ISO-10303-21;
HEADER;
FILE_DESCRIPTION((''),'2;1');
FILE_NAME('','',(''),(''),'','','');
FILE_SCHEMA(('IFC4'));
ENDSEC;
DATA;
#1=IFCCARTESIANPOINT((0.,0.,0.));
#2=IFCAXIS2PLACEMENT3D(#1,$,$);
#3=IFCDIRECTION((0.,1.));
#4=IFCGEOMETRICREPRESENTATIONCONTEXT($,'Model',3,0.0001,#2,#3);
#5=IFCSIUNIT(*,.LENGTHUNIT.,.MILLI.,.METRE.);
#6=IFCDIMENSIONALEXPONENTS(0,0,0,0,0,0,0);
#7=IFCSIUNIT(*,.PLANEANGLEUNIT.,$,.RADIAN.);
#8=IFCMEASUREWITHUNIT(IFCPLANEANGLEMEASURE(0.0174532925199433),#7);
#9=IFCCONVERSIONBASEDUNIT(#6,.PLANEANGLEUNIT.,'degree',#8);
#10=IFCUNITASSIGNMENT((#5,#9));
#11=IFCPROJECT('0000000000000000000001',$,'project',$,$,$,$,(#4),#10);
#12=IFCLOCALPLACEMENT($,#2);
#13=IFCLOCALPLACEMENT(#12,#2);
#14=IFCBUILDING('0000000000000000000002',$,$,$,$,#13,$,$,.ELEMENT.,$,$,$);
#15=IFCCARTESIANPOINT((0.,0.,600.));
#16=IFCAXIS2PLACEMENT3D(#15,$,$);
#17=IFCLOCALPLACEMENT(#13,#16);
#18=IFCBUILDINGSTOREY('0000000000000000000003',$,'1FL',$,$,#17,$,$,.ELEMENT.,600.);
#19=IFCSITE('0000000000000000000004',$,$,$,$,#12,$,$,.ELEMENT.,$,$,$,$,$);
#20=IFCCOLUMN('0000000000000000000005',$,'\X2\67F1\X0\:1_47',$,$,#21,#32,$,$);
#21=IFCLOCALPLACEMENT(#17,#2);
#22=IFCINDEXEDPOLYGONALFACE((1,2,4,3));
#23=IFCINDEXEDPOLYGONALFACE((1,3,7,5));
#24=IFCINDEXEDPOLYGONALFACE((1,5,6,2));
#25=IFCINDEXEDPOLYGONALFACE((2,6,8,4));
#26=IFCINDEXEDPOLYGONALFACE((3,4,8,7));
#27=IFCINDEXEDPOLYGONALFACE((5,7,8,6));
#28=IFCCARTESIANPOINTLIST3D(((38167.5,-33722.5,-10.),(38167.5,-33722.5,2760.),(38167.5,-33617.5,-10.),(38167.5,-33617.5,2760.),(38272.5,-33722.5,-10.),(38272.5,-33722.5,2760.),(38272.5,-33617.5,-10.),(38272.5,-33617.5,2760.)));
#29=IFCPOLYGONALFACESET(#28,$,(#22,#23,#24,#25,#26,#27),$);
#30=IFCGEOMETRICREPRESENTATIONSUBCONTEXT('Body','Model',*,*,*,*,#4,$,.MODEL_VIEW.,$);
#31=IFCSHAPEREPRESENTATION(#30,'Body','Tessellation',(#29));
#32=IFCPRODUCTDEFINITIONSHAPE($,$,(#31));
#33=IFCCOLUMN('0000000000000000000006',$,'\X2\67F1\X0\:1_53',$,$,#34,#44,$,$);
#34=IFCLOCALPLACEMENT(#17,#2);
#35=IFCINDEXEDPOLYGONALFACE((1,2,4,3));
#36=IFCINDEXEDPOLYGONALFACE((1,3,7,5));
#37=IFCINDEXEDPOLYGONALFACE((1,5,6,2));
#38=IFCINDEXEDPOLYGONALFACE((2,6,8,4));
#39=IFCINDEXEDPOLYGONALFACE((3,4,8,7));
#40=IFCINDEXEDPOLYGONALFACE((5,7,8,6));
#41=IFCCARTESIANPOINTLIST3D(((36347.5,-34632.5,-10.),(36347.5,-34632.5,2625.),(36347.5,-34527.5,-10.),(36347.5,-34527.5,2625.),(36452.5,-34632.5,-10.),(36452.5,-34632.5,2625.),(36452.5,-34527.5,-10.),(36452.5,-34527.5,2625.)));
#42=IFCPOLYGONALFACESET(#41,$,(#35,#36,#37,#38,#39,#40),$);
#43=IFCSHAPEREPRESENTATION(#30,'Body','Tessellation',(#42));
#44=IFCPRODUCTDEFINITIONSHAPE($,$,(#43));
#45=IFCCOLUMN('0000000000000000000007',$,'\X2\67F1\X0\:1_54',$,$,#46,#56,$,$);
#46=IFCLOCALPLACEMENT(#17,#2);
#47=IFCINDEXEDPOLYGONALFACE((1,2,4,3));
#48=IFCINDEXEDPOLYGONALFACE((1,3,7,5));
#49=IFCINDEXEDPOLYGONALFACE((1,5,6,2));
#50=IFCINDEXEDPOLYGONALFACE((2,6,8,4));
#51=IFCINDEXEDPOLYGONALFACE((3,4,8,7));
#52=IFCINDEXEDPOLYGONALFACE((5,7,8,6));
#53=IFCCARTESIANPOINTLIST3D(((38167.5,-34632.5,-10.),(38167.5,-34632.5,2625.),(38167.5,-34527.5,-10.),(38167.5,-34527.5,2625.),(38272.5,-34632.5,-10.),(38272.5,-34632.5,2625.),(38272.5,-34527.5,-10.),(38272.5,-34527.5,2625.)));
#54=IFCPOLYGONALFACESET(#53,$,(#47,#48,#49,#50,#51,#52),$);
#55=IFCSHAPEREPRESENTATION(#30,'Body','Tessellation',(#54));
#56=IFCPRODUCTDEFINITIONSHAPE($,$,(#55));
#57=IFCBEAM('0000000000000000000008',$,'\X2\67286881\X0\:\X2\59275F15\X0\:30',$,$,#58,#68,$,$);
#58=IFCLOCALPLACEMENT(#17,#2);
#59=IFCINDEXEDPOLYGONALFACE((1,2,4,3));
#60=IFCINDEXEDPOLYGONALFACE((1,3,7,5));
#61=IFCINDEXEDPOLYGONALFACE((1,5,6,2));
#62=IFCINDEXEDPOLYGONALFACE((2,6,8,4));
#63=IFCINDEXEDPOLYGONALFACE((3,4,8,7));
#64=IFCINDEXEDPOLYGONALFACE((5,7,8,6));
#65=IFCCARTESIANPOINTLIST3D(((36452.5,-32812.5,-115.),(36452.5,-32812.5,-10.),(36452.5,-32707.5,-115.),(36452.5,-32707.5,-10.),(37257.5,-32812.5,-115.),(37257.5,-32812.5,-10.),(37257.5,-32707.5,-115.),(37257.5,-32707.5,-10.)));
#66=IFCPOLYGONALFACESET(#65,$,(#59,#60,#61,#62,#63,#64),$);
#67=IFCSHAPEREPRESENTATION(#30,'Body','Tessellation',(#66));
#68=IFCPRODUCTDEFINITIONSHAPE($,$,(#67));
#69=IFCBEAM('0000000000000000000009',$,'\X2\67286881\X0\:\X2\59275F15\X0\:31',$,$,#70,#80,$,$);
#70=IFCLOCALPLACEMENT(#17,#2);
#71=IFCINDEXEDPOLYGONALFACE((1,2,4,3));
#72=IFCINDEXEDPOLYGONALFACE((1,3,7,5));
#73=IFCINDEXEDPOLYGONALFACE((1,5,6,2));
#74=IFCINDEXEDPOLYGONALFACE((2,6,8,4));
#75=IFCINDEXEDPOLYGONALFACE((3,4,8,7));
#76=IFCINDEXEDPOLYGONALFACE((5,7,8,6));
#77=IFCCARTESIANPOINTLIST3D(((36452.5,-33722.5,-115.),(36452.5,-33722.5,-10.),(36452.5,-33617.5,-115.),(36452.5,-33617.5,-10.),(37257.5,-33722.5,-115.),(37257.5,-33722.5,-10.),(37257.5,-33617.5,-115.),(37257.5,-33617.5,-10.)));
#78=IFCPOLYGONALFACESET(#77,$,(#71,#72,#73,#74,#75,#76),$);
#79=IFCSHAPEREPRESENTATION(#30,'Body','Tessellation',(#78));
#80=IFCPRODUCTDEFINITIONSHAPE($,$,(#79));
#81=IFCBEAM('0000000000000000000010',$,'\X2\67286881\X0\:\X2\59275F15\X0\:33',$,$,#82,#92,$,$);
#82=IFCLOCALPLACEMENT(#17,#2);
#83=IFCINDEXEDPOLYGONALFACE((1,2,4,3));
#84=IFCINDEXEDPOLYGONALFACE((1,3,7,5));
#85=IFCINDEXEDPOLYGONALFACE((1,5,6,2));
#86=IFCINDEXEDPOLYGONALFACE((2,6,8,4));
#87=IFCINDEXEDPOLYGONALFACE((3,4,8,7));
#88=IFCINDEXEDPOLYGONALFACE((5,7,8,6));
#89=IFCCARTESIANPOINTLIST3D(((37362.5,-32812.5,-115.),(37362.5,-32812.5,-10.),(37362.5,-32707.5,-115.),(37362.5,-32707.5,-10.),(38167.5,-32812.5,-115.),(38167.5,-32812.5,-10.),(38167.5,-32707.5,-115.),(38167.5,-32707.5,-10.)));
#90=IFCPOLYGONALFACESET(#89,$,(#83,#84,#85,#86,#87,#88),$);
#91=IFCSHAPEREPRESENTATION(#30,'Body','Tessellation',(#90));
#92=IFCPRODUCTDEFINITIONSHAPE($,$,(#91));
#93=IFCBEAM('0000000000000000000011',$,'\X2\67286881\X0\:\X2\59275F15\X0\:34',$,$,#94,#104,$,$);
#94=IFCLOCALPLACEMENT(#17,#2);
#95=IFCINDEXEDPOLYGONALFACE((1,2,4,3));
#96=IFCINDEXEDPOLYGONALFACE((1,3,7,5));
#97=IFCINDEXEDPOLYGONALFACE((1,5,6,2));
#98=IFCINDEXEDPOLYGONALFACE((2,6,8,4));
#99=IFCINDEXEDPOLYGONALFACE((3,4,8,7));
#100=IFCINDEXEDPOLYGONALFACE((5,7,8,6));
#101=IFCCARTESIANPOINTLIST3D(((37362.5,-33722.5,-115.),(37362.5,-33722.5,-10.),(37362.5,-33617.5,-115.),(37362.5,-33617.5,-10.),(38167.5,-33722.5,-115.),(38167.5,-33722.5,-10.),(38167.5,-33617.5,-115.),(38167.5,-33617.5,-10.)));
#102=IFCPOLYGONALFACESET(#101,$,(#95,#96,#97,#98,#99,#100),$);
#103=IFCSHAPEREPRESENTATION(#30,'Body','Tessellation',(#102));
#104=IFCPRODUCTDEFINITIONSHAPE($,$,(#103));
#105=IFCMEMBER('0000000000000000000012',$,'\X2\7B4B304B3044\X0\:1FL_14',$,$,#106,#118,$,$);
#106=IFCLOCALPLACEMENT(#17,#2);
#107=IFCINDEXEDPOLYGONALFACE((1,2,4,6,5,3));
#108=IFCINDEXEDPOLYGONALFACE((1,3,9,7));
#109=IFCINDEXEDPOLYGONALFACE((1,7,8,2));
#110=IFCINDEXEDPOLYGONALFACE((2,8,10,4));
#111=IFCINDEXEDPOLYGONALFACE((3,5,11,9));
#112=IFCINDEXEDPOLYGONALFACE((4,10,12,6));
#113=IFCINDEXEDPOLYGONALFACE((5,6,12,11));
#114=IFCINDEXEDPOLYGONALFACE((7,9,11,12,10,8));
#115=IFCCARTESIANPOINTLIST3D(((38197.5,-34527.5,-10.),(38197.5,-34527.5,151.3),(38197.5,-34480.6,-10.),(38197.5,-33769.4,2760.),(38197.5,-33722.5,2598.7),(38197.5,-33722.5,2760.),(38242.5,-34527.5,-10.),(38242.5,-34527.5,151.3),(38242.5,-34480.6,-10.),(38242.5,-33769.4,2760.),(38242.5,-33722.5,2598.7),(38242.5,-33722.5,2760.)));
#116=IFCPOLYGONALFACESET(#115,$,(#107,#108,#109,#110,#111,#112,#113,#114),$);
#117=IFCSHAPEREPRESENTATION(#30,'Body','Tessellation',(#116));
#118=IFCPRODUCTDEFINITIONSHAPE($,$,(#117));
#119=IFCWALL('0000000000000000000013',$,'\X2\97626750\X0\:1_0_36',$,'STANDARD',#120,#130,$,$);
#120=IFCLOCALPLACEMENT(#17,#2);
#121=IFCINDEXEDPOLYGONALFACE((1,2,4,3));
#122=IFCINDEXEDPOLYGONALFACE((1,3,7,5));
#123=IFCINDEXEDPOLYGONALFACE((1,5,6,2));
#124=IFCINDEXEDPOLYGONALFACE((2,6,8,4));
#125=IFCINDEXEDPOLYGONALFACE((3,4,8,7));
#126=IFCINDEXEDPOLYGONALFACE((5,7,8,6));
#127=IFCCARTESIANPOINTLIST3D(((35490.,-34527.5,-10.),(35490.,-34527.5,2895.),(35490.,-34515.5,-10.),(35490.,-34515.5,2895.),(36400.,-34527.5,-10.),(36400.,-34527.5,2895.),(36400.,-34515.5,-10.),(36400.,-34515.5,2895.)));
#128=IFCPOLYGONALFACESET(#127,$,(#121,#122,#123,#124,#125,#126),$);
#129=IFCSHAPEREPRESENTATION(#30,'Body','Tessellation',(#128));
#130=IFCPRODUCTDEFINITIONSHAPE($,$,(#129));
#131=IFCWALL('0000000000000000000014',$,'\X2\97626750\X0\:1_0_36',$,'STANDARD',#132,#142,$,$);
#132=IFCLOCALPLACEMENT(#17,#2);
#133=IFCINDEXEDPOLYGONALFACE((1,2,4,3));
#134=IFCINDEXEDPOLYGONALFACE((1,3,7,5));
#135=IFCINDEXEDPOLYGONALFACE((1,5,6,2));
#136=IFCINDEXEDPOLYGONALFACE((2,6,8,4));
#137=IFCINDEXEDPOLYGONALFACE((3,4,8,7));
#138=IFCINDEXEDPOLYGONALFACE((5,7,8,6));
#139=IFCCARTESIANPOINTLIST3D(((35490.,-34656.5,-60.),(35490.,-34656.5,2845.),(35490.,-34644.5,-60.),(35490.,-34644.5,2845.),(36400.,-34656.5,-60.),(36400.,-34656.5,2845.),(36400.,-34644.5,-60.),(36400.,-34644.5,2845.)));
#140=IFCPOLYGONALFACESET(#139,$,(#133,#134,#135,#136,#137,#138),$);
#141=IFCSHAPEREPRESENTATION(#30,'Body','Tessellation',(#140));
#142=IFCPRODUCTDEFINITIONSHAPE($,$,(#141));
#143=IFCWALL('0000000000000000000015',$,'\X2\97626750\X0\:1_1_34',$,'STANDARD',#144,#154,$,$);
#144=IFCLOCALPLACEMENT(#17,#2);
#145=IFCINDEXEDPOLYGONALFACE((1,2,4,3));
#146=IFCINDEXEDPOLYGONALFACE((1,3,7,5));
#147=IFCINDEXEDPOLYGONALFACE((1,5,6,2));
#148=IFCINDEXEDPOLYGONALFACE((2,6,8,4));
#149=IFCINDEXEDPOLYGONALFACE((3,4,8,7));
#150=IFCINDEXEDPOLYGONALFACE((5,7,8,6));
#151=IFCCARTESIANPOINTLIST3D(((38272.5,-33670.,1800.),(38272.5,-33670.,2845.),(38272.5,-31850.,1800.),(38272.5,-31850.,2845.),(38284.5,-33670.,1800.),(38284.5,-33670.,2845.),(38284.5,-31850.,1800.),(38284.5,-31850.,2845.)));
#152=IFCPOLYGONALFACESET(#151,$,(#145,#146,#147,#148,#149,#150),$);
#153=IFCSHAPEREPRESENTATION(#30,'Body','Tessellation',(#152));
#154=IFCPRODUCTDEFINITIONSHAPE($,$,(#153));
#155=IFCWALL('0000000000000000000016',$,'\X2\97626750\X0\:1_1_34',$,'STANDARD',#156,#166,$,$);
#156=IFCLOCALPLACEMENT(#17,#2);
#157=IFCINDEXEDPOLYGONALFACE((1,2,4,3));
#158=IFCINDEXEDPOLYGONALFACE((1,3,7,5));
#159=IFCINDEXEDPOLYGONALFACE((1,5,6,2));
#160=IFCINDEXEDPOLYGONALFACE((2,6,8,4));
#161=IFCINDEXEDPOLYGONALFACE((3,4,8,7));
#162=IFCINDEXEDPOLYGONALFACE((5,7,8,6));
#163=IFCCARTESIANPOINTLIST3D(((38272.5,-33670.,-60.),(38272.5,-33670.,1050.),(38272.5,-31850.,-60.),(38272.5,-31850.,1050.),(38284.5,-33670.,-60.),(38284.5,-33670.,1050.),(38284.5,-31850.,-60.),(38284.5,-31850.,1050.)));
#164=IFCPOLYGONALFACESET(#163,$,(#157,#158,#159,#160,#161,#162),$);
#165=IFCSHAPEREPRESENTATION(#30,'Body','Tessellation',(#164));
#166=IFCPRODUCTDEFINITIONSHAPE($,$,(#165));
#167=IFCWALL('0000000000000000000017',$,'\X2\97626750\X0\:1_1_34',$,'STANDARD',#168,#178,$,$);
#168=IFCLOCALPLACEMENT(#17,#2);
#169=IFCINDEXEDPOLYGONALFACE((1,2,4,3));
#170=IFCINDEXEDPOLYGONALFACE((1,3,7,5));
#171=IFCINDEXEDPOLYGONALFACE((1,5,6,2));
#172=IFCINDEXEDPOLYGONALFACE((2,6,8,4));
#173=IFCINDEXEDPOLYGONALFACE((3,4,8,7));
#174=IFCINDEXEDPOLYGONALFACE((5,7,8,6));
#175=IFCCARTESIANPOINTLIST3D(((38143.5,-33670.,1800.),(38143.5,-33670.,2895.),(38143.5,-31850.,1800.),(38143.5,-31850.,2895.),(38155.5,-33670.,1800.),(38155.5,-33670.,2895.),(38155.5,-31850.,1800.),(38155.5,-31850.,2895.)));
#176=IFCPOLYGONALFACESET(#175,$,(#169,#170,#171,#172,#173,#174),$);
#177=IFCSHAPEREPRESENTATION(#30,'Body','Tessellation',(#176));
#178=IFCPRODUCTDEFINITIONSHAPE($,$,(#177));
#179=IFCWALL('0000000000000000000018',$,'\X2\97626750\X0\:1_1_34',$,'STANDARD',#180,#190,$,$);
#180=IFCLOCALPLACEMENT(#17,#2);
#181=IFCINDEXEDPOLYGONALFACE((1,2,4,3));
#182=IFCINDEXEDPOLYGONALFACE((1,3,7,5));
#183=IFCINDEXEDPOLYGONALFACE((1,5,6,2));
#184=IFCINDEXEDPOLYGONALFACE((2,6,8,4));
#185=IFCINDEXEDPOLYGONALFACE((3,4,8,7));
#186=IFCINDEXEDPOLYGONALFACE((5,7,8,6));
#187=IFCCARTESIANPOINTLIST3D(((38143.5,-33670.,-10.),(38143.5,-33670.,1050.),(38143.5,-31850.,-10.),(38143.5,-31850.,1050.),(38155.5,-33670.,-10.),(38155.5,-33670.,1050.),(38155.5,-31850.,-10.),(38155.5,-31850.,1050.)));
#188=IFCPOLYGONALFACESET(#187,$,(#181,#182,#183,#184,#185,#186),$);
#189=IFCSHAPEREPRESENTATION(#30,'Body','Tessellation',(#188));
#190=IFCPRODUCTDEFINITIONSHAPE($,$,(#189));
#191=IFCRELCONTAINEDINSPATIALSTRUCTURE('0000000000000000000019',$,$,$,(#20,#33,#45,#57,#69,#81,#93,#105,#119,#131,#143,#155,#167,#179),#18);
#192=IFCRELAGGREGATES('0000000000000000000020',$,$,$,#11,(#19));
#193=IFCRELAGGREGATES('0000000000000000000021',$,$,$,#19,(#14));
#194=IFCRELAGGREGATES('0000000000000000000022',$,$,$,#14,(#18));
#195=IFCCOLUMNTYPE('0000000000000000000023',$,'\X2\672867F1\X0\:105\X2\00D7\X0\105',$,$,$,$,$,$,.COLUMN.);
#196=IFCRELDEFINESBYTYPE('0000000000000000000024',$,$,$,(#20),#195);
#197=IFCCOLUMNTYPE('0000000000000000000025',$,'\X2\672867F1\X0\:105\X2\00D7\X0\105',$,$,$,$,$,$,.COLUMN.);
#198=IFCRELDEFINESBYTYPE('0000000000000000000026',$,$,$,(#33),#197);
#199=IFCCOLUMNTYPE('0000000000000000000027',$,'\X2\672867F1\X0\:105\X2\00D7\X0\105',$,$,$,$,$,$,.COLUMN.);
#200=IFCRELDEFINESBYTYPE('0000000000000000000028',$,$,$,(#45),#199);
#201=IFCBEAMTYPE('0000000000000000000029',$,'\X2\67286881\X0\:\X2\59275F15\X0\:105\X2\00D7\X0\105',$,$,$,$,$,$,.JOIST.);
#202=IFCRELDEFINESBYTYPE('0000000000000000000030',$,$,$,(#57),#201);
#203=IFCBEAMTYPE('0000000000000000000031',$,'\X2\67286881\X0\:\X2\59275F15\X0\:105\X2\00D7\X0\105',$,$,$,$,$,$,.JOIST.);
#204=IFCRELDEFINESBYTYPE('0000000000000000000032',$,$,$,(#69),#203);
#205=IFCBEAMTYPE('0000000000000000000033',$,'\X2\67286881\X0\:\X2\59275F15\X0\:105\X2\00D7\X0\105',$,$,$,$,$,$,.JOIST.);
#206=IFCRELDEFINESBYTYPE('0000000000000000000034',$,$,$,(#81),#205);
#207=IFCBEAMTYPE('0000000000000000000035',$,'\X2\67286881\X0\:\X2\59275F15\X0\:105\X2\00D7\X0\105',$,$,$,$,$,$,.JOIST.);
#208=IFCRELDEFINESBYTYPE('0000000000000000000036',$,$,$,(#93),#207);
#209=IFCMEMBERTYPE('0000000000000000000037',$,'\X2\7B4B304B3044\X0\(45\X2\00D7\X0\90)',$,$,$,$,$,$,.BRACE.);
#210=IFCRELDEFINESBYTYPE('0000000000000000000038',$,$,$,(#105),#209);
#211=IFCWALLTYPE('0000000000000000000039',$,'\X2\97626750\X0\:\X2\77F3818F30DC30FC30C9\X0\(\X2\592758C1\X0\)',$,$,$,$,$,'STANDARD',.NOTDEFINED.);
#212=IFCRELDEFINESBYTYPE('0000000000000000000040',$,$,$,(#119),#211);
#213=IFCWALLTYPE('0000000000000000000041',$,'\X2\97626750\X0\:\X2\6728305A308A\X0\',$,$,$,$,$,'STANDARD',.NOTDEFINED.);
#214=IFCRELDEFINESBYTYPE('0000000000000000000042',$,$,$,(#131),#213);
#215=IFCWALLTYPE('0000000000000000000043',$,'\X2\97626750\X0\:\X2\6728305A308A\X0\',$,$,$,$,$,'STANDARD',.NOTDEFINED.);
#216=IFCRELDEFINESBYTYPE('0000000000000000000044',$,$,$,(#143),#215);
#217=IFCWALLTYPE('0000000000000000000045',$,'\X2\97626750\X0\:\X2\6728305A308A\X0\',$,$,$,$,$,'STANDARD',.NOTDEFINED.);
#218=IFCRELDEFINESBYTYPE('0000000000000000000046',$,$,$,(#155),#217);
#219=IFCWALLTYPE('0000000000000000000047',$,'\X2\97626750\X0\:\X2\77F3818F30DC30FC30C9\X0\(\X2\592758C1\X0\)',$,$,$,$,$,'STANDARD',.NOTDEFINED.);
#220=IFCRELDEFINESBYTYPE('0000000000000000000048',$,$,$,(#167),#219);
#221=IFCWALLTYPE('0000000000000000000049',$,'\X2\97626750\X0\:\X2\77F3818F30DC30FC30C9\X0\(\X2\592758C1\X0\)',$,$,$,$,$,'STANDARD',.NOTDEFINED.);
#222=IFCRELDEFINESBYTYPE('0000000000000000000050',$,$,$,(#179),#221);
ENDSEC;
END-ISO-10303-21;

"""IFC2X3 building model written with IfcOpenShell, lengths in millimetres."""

from ifc_helpers import new_model, entity, si_unit, converted_unit, direction, frame, origin, origin_with_axes, origin_2d, place, context, subcontext, project, spatial, polyline, rectangle, outline, extrude, type_object, element, save


model = new_model("IFC2X3")

# Units and contexts
model_context = context("Model", 3, precision=0.0001, world=origin(), true_north=direction((0.0, 1.0)))
body_context = subcontext(model_context, "Body", "Model", "MODEL_VIEW")
ifc_project = project(units=[si_unit("LENGTHUNIT", "METRE", prefix="MILLI"), converted_unit("PLANEANGLEUNIT", "degree", entity("IfcPlaneAngleMeasure", 0.0174532925199433), si_unit("PLANEANGLEUNIT", "RADIAN"), dimensions=[0, 0, 0, 0, 0, 0, 0])], contexts=[model_context])

# Site, building, storey
site_placement = place(None, origin())
site = spatial("IfcSite", under=ifc_project, at=site_placement, CompositionType="ELEMENT")
building_placement = place(site_placement, origin())
building = spatial("IfcBuilding", under=site, at=building_placement, CompositionType="ELEMENT")
storey_placement = place(building_placement, frame((0.0, 0.0, 600.0)))
storey = spatial("IfcBuildingStorey", under=building, at=storey_placement, Name="1FL", CompositionType="ELEMENT", Elevation=600.0)

# Columns
column_type_1 = type_object("IfcColumnType", Name="木柱:105×105", PredefinedType="COLUMN")
column_1_placement = place(storey_placement, frame((38220.0, -33670.0, -10.0)))
element("IfcColumn", 1, at=column_1_placement, inside=storey, type_object=column_type_1, Name="柱:1_47", context=body_context, shape_type="SweptSolid", body=[
    extrude(rectangle(XDim=105.0, YDim=105.0, at=origin_2d()), origin_with_axes(), (0.0, 0.0, 1.0), 2770.0),
])
column_type_2 = type_object("IfcColumnType", Name="木柱:105×105", PredefinedType="COLUMN")
column_2_placement = place(storey_placement, frame((36400.0, -34580.0, -10.0)))
element("IfcColumn", 2, at=column_2_placement, inside=storey, type_object=column_type_2, Name="柱:1_53", context=body_context, shape_type="SweptSolid", body=[
    extrude(rectangle(XDim=105.0, YDim=105.0, at=origin_2d()), origin_with_axes(), (0.0, 0.0, 1.0), 2635.0),
])
column_type_3 = type_object("IfcColumnType", Name="木柱:105×105", PredefinedType="COLUMN")
column_3_placement = place(storey_placement, frame((38220.0, -34580.0, -10.0)))
element("IfcColumn", 3, at=column_3_placement, inside=storey, type_object=column_type_3, Name="柱:1_54", context=body_context, shape_type="SweptSolid", body=[
    extrude(rectangle(XDim=105.0, YDim=105.0, at=origin_2d()), origin_with_axes(), (0.0, 0.0, 1.0), 2635.0),
])

# Beams
beam_type_1 = type_object("IfcBeamType", Name="木梁:大引:105×105", PredefinedType="JOIST")
beam_1_placement = place(storey_placement, frame((36452.5, -32760.0, -62.5), z_axis=(1.0, 0.0, 0.0), x_axis=(0.0, 1.0, 0.0)))
element("IfcBeam", 4, at=beam_1_placement, inside=storey, type_object=beam_type_1, Name="木梁:大引:30", context=body_context, shape_type="SweptSolid", body=[
    extrude(rectangle(XDim=105.0, YDim=105.0, at=origin_2d()), origin_with_axes(), (0.0, 0.0, 1.0), 805.0),
])
beam_type_2 = type_object("IfcBeamType", Name="木梁:大引:105×105", PredefinedType="JOIST")
beam_2_placement = place(storey_placement, frame((36452.5, -33670.0, -62.5), z_axis=(1.0, 0.0, 0.0), x_axis=(0.0, 1.0, 0.0)))
element("IfcBeam", 5, at=beam_2_placement, inside=storey, type_object=beam_type_2, Name="木梁:大引:31", context=body_context, shape_type="SweptSolid", body=[
    extrude(rectangle(XDim=105.0, YDim=105.0, at=origin_2d()), origin_with_axes(), (0.0, 0.0, 1.0), 805.0),
])
beam_type_3 = type_object("IfcBeamType", Name="木梁:大引:105×105", PredefinedType="JOIST")
beam_3_placement = place(storey_placement, frame((37362.5, -32760.0, -62.5), z_axis=(1.0, 0.0, 0.0), x_axis=(0.0, 1.0, 0.0)))
element("IfcBeam", 6, at=beam_3_placement, inside=storey, type_object=beam_type_3, Name="木梁:大引:33", context=body_context, shape_type="SweptSolid", body=[
    extrude(rectangle(XDim=105.0, YDim=105.0, at=origin_2d()), origin_with_axes(), (0.0, 0.0, 1.0), 805.0),
])
beam_type_4 = type_object("IfcBeamType", Name="木梁:大引:105×105", PredefinedType="JOIST")
beam_4_placement = place(storey_placement, frame((37362.5, -33670.0, -62.5), z_axis=(1.0, 0.0, 0.0), x_axis=(0.0, 1.0, 0.0)))
element("IfcBeam", 7, at=beam_4_placement, inside=storey, type_object=beam_type_4, Name="木梁:大引:34", context=body_context, shape_type="SweptSolid", body=[
    extrude(rectangle(XDim=105.0, YDim=105.0, at=origin_2d()), origin_with_axes(), (0.0, 0.0, 1.0), 805.0),
])

# Member
member_type = type_object("IfcMemberType", Name="筋かい(45×90)", PredefinedType="BRACE")
member_placement = place(storey_placement, frame((38220.0, -34527.5, -10.0), z_axis=(0.0, 0.279068, 0.960271), x_axis=(0.0, -0.960271, 0.279068)))
element("IfcMember", 8, at=member_placement, inside=storey, type_object=member_type, Name="筋かい:1FL_14", context=body_context, shape_type="SweptSolid", body=[
    extrude(outline(polyline([(0.0, 0.0), (13.1, -45.0), (2729.8, -45.0), (2884.6, 0.0), (2871.5, 45.0), (154.8, 45.0), (0.0, 0.0)])), frame((0.0, -22.5, 0.0), z_axis=(0.0, 1.0, 0.0), x_axis=(0.0, 0.0, 1.0)), (0.0, 0.0, 1.0), 45.0),
])

# Walls
wall_type_1 = type_object("IfcWallType", Name="面材:石膏ボード(大壁)", ElementType="STANDARD", PredefinedType="NOTDEFINED")
wall_1_placement = place(storey_placement, frame((35945.0, -34515.5, -10.0), z_axis=(0.0, -1.0, 0.0), x_axis=(1.0, 0.0, 0.0)))
element("IfcWall", 9, at=wall_1_placement, inside=storey, type_object=wall_type_1, Name="面材:1_0_36", ObjectType="STANDARD", context=body_context, shape_type="SweptSolid", body=[
    extrude(outline(polyline([(455.0, 0.0, 0.0), (-455.0, 0.0, 0.0), (-455.0, 2905.0, 0.0), (455.0, 2905.0, 0.0), (455.0, 0.0, 0.0)])), origin_with_axes(), (0.0, 0.0, 1.0), 12.0),
])
wall_type_2 = type_object("IfcWallType", Name="面材:木ずり", ElementType="STANDARD", PredefinedType="NOTDEFINED")
wall_2_placement = place(storey_placement, frame((35945.0, -34644.5, -60.0), z_axis=(0.0, -1.0, 0.0), x_axis=(1.0, 0.0, 0.0)))
element("IfcWall", 10, at=wall_2_placement, inside=storey, type_object=wall_type_2, Name="面材:1_0_36", ObjectType="STANDARD", context=body_context, shape_type="SweptSolid", body=[
    extrude(outline(polyline([(455.0, 0.0, 0.0), (-455.0, 0.0, 0.0), (-455.0, 2905.0, 0.0), (455.0, 2905.0, 0.0), (455.0, 0.0, 0.0)])), origin_with_axes(), (0.0, 0.0, 1.0), 12.0),
])
wall_type_3 = type_object("IfcWallType", Name="面材:木ずり", ElementType="STANDARD", PredefinedType="NOTDEFINED")
wall_3_placement = place(storey_placement, frame((38284.5, -32760.0, 1800.0), z_axis=(-1.0, 0.0, 0.0), x_axis=(0.0, -1.0, 0.0)))
element("IfcWall", 11, at=wall_3_placement, inside=storey, type_object=wall_type_3, Name="面材:1_1_34", ObjectType="STANDARD", context=body_context, shape_type="SweptSolid", body=[
    extrude(outline(polyline([(-910.0, 0.0, 0.0), (-910.0, 1045.0, 0.0), (910.0, 1045.0, 0.0), (910.0, 0.0, 0.0), (-910.0, 0.0, 0.0)])), origin_with_axes(), (0.0, 0.0, 1.0), 12.0),
])
wall_type_4 = type_object("IfcWallType", Name="面材:木ずり", ElementType="STANDARD", PredefinedType="NOTDEFINED")
wall_4_placement = place(storey_placement, frame((38284.5, -32760.0, -60.0), z_axis=(-1.0, 0.0, 0.0), x_axis=(0.0, -1.0, 0.0)))
element("IfcWall", 12, at=wall_4_placement, inside=storey, type_object=wall_type_4, Name="面材:1_1_34", ObjectType="STANDARD", context=body_context, shape_type="SweptSolid", body=[
    extrude(outline(polyline([(-910.0, 1110.0, 0.0), (910.0, 1110.0, 0.0), (910.0, 0.0, 0.0), (-910.0, 0.0, 0.0), (-910.0, 1110.0, 0.0)])), origin_with_axes(), (0.0, 0.0, 1.0), 12.0),
])
wall_type_5 = type_object("IfcWallType", Name="面材:石膏ボード(大壁)", ElementType="STANDARD", PredefinedType="NOTDEFINED")
wall_5_placement = place(storey_placement, frame((38155.5, -32760.0, 1800.0), z_axis=(-1.0, 0.0, 0.0), x_axis=(0.0, -1.0, 0.0)))
element("IfcWall", 13, at=wall_5_placement, inside=storey, type_object=wall_type_5, Name="面材:1_1_34", ObjectType="STANDARD", context=body_context, shape_type="SweptSolid", body=[
    extrude(outline(polyline([(-910.0, 0.0, 0.0), (-910.0, 1095.0, 0.0), (910.0, 1095.0, 0.0), (910.0, 0.0, 0.0), (-910.0, 0.0, 0.0)])), origin_with_axes(), (0.0, 0.0, 1.0), 12.0),
])
wall_type_6 = type_object("IfcWallType", Name="面材:石膏ボード(大壁)", ElementType="STANDARD", PredefinedType="NOTDEFINED")
wall_6_placement = place(storey_placement, frame((38155.5, -32760.0, -10.0), z_axis=(-1.0, 0.0, 0.0), x_axis=(0.0, -1.0, 0.0)))
element("IfcWall", 14, at=wall_6_placement, inside=storey, type_object=wall_type_6, Name="面材:1_1_34", ObjectType="STANDARD", context=body_context, shape_type="SweptSolid", body=[
    extrude(outline(polyline([(-910.0, 1060.0, 0.0), (910.0, 1060.0, 0.0), (910.0, 0.0, 0.0), (-910.0, 0.0, 0.0), (-910.0, 1060.0, 0.0)])), origin_with_axes(), (0.0, 0.0, 1.0), 12.0),
])

save(model, "model.ifc")
